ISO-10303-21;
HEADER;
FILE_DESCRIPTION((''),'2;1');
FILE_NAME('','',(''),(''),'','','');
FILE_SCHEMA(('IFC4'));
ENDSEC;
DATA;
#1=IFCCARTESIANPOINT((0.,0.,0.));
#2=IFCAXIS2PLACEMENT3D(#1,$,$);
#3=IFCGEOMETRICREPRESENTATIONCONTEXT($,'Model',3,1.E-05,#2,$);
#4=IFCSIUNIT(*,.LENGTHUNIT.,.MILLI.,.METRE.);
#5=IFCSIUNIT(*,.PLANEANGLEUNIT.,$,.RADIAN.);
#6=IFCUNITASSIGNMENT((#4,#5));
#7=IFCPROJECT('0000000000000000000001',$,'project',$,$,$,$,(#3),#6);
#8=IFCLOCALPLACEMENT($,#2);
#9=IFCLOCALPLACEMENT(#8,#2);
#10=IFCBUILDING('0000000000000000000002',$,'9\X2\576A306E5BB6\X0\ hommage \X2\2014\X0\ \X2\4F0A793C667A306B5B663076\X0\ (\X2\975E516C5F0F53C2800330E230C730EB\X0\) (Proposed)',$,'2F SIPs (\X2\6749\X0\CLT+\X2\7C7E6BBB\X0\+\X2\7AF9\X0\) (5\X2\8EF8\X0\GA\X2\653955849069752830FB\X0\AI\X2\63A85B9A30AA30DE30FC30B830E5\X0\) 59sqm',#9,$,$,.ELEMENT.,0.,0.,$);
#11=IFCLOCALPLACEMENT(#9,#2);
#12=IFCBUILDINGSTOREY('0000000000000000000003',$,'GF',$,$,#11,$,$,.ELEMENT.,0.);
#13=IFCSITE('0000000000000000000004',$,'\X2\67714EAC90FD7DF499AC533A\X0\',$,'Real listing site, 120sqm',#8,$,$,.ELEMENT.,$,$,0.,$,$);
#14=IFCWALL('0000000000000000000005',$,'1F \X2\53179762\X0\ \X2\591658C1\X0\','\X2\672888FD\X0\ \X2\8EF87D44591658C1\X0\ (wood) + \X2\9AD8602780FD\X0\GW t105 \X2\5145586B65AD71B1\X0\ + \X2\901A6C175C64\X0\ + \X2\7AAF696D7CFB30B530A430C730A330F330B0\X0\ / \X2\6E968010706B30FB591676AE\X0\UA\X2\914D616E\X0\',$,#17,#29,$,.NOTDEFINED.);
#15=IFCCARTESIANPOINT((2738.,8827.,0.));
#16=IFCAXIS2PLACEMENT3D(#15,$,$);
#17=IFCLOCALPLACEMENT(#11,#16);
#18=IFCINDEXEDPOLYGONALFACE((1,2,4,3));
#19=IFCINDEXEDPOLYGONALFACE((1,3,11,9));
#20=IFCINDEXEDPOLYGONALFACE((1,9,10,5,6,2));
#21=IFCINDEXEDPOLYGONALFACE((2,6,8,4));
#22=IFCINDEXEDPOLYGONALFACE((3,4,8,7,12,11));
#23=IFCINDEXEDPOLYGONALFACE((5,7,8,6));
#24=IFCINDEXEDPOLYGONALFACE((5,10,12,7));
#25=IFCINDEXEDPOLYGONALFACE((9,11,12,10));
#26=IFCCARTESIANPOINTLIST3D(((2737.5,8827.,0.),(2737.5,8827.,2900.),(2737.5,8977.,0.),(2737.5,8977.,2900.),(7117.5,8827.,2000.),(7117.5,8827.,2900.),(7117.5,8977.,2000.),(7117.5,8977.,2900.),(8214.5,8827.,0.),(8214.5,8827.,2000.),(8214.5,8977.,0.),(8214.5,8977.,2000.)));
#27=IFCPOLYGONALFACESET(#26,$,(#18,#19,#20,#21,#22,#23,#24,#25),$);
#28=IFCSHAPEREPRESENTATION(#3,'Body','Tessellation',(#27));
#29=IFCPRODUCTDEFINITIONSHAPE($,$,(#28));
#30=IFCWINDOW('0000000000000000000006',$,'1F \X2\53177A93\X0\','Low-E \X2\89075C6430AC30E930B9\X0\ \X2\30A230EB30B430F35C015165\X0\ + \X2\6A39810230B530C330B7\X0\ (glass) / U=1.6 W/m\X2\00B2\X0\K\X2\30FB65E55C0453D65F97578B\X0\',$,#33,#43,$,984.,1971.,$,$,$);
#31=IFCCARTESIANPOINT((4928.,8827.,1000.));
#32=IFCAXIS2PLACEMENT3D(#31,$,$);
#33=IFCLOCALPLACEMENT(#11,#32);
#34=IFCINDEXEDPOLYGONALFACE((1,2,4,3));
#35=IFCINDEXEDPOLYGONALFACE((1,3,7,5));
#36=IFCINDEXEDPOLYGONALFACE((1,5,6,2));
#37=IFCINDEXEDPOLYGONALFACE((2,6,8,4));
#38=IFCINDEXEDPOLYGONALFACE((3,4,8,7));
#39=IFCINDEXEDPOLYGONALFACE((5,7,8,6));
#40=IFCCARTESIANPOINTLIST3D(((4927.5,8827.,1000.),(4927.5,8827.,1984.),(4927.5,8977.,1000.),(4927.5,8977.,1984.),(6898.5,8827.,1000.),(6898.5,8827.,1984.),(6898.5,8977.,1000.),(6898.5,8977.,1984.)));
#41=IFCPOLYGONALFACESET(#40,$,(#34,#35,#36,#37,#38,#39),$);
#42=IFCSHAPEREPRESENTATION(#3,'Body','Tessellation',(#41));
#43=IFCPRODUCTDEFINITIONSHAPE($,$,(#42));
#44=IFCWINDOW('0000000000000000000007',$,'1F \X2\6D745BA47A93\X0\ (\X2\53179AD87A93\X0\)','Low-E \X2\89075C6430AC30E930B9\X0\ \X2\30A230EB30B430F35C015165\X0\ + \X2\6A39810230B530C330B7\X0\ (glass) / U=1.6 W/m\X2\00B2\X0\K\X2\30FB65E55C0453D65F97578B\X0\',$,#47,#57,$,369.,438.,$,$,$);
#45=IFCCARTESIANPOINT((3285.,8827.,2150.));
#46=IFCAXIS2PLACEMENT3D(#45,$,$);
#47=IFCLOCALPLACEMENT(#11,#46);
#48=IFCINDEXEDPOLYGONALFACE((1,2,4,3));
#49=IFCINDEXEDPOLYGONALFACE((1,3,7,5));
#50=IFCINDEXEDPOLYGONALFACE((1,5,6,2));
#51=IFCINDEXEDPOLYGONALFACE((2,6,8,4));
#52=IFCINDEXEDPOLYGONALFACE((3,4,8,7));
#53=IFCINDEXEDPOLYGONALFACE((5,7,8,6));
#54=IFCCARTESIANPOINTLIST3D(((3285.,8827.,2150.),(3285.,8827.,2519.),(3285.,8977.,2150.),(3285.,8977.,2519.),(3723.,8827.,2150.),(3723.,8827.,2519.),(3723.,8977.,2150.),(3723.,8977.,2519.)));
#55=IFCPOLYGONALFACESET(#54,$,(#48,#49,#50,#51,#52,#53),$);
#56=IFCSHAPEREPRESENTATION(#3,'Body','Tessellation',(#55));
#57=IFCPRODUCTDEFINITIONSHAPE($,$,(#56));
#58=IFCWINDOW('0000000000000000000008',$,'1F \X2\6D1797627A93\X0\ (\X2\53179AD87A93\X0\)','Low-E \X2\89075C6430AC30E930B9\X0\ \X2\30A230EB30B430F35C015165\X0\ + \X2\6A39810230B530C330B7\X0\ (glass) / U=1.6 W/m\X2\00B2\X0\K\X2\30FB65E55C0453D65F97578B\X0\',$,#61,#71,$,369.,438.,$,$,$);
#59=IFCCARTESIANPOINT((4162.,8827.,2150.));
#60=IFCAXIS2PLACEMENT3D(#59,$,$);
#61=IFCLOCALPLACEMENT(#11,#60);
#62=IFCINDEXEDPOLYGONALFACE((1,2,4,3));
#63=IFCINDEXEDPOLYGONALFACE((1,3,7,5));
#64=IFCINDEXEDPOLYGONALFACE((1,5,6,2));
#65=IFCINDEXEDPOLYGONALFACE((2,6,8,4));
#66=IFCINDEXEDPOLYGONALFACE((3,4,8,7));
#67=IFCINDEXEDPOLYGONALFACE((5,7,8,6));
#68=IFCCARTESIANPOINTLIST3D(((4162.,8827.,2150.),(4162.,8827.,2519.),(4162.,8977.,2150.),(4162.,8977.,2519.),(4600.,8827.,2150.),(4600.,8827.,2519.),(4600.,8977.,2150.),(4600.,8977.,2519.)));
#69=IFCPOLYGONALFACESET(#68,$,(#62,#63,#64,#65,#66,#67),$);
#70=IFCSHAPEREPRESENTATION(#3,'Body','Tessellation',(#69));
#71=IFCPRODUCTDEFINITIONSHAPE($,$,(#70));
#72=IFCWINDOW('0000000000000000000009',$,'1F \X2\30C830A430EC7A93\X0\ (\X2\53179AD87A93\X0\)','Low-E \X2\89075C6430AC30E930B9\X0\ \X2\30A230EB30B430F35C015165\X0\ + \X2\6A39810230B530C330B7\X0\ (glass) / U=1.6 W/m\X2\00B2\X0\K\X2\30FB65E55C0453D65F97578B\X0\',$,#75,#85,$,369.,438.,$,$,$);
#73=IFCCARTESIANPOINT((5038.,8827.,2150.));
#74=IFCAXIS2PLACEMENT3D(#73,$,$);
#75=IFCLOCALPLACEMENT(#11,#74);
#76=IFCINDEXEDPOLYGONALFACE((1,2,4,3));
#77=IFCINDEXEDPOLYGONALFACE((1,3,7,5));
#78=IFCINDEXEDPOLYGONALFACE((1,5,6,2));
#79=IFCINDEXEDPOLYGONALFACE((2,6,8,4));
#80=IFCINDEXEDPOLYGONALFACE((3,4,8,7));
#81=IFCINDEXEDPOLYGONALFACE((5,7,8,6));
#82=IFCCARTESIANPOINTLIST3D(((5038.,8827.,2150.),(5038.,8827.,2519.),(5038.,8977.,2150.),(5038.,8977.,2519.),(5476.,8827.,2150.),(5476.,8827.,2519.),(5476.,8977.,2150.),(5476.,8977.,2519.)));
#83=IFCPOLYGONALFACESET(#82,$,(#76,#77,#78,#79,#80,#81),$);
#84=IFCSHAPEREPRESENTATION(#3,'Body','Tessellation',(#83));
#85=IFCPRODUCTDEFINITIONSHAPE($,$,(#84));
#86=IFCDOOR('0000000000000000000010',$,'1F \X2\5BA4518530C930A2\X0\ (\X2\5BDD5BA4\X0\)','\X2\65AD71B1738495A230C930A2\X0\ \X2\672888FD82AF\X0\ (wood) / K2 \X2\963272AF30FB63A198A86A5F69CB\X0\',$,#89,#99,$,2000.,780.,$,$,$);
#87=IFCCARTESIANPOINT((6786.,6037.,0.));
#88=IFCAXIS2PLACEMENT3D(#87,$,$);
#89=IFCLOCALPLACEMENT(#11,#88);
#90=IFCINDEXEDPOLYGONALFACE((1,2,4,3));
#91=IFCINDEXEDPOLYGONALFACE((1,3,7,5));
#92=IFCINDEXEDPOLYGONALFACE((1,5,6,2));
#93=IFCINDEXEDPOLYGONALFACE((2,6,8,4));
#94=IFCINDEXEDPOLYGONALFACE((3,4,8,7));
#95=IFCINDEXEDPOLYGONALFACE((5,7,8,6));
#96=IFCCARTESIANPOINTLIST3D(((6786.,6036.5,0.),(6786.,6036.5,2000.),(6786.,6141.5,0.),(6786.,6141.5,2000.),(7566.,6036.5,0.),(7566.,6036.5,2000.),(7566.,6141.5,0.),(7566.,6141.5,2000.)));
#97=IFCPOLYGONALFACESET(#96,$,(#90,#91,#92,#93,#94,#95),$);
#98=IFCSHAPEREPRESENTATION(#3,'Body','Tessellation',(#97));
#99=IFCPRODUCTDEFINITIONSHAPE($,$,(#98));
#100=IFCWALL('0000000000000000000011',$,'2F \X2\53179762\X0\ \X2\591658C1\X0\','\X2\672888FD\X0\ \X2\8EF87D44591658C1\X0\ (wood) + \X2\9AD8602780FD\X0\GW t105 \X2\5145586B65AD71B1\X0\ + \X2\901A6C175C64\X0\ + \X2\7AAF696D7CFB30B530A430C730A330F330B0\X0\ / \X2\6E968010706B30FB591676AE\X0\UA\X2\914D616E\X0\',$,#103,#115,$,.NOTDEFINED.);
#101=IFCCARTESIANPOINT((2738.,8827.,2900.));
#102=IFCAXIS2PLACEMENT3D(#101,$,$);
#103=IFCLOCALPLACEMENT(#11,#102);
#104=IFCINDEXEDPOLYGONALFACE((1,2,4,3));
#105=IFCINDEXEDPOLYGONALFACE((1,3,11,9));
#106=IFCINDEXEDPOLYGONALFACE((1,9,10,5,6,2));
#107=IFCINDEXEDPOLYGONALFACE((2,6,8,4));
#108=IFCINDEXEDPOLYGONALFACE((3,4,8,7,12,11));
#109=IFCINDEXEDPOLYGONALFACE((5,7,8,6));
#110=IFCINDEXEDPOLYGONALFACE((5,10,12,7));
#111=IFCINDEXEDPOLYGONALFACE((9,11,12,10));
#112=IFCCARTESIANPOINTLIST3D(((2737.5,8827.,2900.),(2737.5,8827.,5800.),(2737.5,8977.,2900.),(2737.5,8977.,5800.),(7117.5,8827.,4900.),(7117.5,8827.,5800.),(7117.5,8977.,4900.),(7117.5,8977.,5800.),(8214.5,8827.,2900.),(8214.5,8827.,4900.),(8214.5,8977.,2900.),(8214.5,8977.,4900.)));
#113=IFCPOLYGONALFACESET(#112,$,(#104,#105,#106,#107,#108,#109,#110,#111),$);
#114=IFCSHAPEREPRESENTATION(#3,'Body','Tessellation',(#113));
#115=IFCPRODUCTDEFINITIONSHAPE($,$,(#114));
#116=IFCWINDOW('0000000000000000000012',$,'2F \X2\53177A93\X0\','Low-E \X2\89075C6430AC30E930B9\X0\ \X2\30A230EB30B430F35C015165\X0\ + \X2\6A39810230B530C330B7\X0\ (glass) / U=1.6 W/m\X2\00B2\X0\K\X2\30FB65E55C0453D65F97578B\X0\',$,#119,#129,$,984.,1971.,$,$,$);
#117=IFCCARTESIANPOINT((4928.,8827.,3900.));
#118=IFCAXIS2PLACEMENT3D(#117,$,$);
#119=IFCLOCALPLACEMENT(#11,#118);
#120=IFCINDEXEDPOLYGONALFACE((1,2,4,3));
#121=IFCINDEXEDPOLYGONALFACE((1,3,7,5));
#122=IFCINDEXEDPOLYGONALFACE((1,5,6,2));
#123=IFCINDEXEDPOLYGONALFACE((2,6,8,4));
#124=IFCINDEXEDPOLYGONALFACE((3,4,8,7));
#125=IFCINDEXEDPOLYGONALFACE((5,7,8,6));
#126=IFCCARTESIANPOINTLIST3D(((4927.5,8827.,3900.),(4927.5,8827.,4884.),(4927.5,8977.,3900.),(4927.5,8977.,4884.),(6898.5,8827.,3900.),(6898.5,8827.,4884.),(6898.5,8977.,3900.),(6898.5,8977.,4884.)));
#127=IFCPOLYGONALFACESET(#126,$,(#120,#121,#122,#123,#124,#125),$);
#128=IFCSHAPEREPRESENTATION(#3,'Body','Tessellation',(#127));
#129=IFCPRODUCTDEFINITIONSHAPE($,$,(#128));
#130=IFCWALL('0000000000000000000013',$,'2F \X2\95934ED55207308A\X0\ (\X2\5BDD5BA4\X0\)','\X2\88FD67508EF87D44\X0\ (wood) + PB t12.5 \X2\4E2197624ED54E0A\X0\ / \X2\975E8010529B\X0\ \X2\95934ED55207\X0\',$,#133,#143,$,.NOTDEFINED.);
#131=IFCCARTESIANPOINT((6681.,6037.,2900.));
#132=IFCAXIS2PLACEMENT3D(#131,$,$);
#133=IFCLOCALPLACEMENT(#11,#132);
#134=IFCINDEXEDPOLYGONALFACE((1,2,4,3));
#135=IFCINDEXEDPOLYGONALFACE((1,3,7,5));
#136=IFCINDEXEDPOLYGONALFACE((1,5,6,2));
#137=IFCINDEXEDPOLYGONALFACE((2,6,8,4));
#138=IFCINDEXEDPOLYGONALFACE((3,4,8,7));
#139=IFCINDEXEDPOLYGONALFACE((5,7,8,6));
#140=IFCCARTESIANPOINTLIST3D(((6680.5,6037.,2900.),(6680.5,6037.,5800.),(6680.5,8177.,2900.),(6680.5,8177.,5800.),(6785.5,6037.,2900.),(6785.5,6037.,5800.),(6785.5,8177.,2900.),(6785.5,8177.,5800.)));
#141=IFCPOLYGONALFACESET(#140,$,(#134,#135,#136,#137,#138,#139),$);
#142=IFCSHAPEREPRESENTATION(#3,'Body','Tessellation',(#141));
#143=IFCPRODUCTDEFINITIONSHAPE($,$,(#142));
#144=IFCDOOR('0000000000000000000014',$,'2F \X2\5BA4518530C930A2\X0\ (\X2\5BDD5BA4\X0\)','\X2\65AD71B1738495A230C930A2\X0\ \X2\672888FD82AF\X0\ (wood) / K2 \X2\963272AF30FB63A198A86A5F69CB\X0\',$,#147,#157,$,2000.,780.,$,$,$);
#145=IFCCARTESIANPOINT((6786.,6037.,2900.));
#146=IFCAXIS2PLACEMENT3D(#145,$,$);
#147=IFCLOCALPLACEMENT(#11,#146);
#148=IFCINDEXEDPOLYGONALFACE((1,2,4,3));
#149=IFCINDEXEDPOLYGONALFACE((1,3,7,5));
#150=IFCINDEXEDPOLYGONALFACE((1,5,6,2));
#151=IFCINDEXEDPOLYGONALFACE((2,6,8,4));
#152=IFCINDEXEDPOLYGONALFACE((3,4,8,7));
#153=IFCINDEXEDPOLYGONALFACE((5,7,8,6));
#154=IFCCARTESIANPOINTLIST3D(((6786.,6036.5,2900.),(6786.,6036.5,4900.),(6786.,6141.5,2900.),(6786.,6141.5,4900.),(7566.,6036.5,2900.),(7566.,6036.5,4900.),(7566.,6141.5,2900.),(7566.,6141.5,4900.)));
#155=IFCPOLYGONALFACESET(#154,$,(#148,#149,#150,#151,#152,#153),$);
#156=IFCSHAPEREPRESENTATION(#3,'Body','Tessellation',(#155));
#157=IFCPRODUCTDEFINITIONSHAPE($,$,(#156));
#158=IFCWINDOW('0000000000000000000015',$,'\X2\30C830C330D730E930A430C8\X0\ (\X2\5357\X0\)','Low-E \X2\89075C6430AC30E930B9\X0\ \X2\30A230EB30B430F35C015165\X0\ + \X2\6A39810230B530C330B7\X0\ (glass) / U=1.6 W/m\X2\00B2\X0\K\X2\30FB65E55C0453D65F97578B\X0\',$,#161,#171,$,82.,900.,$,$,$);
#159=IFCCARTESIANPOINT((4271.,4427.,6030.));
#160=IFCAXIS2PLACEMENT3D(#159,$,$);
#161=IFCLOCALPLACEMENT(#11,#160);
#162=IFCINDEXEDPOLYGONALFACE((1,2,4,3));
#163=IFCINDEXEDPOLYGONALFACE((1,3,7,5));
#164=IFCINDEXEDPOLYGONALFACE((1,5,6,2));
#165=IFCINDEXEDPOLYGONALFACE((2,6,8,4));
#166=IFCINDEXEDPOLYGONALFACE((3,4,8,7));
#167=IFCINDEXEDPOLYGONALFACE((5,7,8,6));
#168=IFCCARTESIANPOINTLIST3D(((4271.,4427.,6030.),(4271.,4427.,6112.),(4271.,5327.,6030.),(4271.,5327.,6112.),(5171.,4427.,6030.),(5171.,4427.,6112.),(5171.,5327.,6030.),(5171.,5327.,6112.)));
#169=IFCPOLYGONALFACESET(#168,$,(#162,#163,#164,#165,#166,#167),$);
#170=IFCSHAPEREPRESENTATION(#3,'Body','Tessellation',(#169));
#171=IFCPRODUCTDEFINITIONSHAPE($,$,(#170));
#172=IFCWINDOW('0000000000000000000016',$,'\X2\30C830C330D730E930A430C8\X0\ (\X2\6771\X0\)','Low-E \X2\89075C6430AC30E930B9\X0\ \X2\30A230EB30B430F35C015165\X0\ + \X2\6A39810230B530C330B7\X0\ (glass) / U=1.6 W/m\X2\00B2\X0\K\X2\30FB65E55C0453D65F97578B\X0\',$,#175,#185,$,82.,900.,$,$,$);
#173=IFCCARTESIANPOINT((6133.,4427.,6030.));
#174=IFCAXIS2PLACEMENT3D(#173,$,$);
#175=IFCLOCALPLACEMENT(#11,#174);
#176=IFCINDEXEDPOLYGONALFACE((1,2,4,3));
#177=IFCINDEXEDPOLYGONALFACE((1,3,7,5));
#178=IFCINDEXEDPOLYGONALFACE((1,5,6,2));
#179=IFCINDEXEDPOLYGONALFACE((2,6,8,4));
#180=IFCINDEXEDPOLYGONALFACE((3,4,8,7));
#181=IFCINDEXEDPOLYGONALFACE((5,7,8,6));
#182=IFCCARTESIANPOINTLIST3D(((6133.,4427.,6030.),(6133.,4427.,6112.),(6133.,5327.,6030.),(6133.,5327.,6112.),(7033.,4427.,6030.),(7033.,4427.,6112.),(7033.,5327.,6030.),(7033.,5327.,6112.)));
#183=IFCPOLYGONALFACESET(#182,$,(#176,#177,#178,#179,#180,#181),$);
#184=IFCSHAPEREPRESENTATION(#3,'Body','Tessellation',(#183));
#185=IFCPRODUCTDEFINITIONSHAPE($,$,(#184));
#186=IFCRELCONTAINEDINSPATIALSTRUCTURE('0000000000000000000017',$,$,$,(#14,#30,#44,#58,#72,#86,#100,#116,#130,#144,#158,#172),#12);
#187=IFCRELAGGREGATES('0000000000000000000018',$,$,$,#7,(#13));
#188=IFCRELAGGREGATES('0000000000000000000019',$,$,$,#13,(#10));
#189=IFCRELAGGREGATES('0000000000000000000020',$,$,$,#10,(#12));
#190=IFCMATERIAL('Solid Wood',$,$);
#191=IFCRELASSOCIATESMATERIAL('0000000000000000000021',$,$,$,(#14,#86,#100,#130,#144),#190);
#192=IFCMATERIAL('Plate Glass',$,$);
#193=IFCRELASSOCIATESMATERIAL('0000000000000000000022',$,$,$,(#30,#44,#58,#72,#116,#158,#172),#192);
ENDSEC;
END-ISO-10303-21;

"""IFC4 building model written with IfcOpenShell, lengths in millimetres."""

from ifc_helpers import new_model, si_unit, frame, frame_2d, origin, place, context, project, spatial, rectangle, extrude, material, element, fill, save


model = new_model("IFC4")

# Units and contexts
model_context = context("Model", 3, precision=1e-05, world=origin())
ifc_project = project(units=[si_unit("LENGTHUNIT", "METRE", prefix="MILLI"), si_unit("PLANEANGLEUNIT", "RADIAN")], contexts=[model_context])

# Site, building, storey
site_placement = place(None, origin())
site = spatial("IfcSite", under=ifc_project, at=site_placement, Name="東京都練馬区", ObjectType="Real listing site, 120sqm", CompositionType="ELEMENT", RefElevation=0.0)
building_placement = place(site_placement, origin())
building = spatial("IfcBuilding", under=site, at=building_placement, Name="9坪の家 hommage — 伊礼智に学ぶ (非公式参考モデル) (Proposed)", ObjectType="2F SIPs (杉CLT+籾殻+竹) (5軸GA改善適用・AI推定オマージュ) 59sqm", CompositionType="ELEMENT", ElevationOfRefHeight=0.0, ElevationOfTerrain=0.0)
storey_placement = place(building_placement, origin())
storey = spatial("IfcBuildingStorey", under=building, at=storey_placement, Name="GF", CompositionType="ELEMENT", Elevation=0.0)

# Wall, openings, windows
ifc_material_1 = material(Name="Solid Wood")
wall_1_placement = place(storey_placement, frame((2738.0, 8827.0, 0.0)))
wall_1 = element("IfcWall", 1, at=wall_1_placement, inside=storey, material=ifc_material_1, Name="1F 北面 外壁", Description="木製 軸組外壁 (wood) + 高性能GW t105 充填断熱 + 通気層 + 窯業系サイディング / 準耐火・外皮UA配慮", PredefinedType="NOTDEFINED", context=model_context, shape_type="SweptSolid", body=[
    extrude(rectangle(XDim=5477.0, YDim=150.0, at=frame_2d((2738.0, 75.0))), frame((2738.0, 8827.0, 0.0)), (0.0, 0.0, 1.0), 2900.0),
])
opening_1_placement = place(storey_placement, frame((4928.0, 8827.0, 1000.0)))
opening_1 = element("IfcOpeningElement", 2, at=opening_1_placement, cuts=wall_1, PredefinedType="NOTDEFINED", context=model_context, shape_type="SweptSolid", body=[
    extrude(rectangle(XDim=1971.0, YDim=150.0, at=frame_2d((985.0, 75.0))), frame((4928.0, 8827.0, 1000.0)), (0.0, 0.0, 1.0), 984.0),
])
opening_2_placement = place(storey_placement, frame((3285.0, 8827.0, 2150.0)))
opening_2 = element("IfcOpeningElement", 3, at=opening_2_placement, cuts=wall_1, PredefinedType="NOTDEFINED", context=model_context, shape_type="SweptSolid", body=[
    extrude(rectangle(XDim=438.0, YDim=150.0, at=frame_2d((219.0, 75.0))), frame((3285.0, 8827.0, 2150.0)), (0.0, 0.0, 1.0), 369.0),
])
opening_3_placement = place(storey_placement, frame((4162.0, 8827.0, 2150.0)))
opening_3 = element("IfcOpeningElement", 4, at=opening_3_placement, cuts=wall_1, PredefinedType="NOTDEFINED", context=model_context, shape_type="SweptSolid", body=[
    extrude(rectangle(XDim=438.0, YDim=150.0, at=frame_2d((219.0, 75.0))), frame((4162.0, 8827.0, 2150.0)), (0.0, 0.0, 1.0), 369.0),
])
opening_4_placement = place(storey_placement, frame((5038.0, 8827.0, 2150.0)))
opening_4 = element("IfcOpeningElement", 5, at=opening_4_placement, cuts=wall_1, PredefinedType="NOTDEFINED", context=model_context, shape_type="SweptSolid", body=[
    extrude(rectangle(XDim=438.0, YDim=150.0, at=frame_2d((219.0, 75.0))), frame((5038.0, 8827.0, 2150.0)), (0.0, 0.0, 1.0), 369.0),
])
ifc_material_2 = material(Name="Plate Glass")
window_1_placement = place(storey_placement, frame((4928.0, 8827.0, 1000.0)))
window_1 = element("IfcWindow", 6, at=window_1_placement, inside=storey, material=ifc_material_2, Name="1F 北窓", Description="Low-E 複層ガラス アルゴン封入 + 樹脂サッシ (glass) / U=1.6 W/m²K・日射取得型", OverallHeight=984.0, OverallWidth=1971.0, context=model_context, shape_type="SweptSolid", body=[
    extrude(rectangle(XDim=1971.0, YDim=150.0, at=frame_2d((985.0, 75.0))), frame((4928.0, 8827.0, 1000.0)), (0.0, 0.0, 1.0), 984.0),
])
fill(opening_1, window_1)
window_2_placement = place(storey_placement, frame((3285.0, 8827.0, 2150.0)))
window_2 = element("IfcWindow", 7, at=window_2_placement, inside=storey, material=ifc_material_2, Name="1F 浴室窓 (北高窓)", Description="Low-E 複層ガラス アルゴン封入 + 樹脂サッシ (glass) / U=1.6 W/m²K・日射取得型", OverallHeight=369.0, OverallWidth=438.0, context=model_context, shape_type="SweptSolid", body=[
    extrude(rectangle(XDim=438.0, YDim=150.0, at=frame_2d((219.0, 75.0))), frame((3285.0, 8827.0, 2150.0)), (0.0, 0.0, 1.0), 369.0),
])
fill(opening_2, window_2)
window_3_placement = place(storey_placement, frame((4162.0, 8827.0, 2150.0)))
window_3 = element("IfcWindow", 8, at=window_3_placement, inside=storey, material=ifc_material_2, Name="1F 洗面窓 (北高窓)", Description="Low-E 複層ガラス アルゴン封入 + 樹脂サッシ (glass) / U=1.6 W/m²K・日射取得型", OverallHeight=369.0, OverallWidth=438.0, context=model_context, shape_type="SweptSolid", body=[
    extrude(rectangle(XDim=438.0, YDim=150.0, at=frame_2d((219.0, 75.0))), frame((4162.0, 8827.0, 2150.0)), (0.0, 0.0, 1.0), 369.0),
])
fill(opening_3, window_3)
window_4_placement = place(storey_placement, frame((5038.0, 8827.0, 2150.0)))
window_4 = element("IfcWindow", 9, at=window_4_placement, inside=storey, material=ifc_material_2, Name="1F トイレ窓 (北高窓)", Description="Low-E 複層ガラス アルゴン封入 + 樹脂サッシ (glass) / U=1.6 W/m²K・日射取得型", OverallHeight=369.0, OverallWidth=438.0, context=model_context, shape_type="SweptSolid", body=[
    extrude(rectangle(XDim=438.0, YDim=150.0, at=frame_2d((219.0, 75.0))), frame((5038.0, 8827.0, 2150.0)), (0.0, 0.0, 1.0), 369.0),
])
fill(opening_4, window_4)

# Door
door_1_placement = place(storey_placement, frame((6786.0, 6037.0, 0.0)))
element("IfcDoor", 10, at=door_1_placement, inside=storey, material=ifc_material_1, Name="1F 室内ドア (寝室)", Description="断熱玄関ドア 木製芯 (wood) / K2 防犯・採風機構", OverallHeight=2000.0, OverallWidth=780.0, context=model_context, shape_type="SweptSolid", body=[
    extrude(rectangle(XDim=780.0, YDim=105.0, at=frame_2d((390.0, 52.0))), frame((6786.0, 6037.0, 0.0)), (0.0, 0.0, 1.0), 2000.0),
])

# Wall, opening, window
wall_2_placement = place(storey_placement, frame((2738.0, 8827.0, 2900.0)))
wall_2 = element("IfcWall", 11, at=wall_2_placement, inside=storey, material=ifc_material_1, Name="2F 北面 外壁", Description="木製 軸組外壁 (wood) + 高性能GW t105 充填断熱 + 通気層 + 窯業系サイディング / 準耐火・外皮UA配慮", PredefinedType="NOTDEFINED", context=model_context, shape_type="SweptSolid", body=[
    extrude(rectangle(XDim=5477.0, YDim=150.0, at=frame_2d((2738.0, 75.0))), frame((2738.0, 8827.0, 2900.0)), (0.0, 0.0, 1.0), 2900.0),
])
opening_5_placement = place(storey_placement, frame((4928.0, 8827.0, 3900.0)))
opening_5 = element("IfcOpeningElement", 12, at=opening_5_placement, cuts=wall_2, PredefinedType="NOTDEFINED", context=model_context, shape_type="SweptSolid", body=[
    extrude(rectangle(XDim=1971.0, YDim=150.0, at=frame_2d((985.0, 75.0))), frame((4928.0, 8827.0, 3900.0)), (0.0, 0.0, 1.0), 984.0),
])
window_5_placement = place(storey_placement, frame((4928.0, 8827.0, 3900.0)))
window_5 = element("IfcWindow", 13, at=window_5_placement, inside=storey, material=ifc_material_2, Name="2F 北窓", Description="Low-E 複層ガラス アルゴン封入 + 樹脂サッシ (glass) / U=1.6 W/m²K・日射取得型", OverallHeight=984.0, OverallWidth=1971.0, context=model_context, shape_type="SweptSolid", body=[
    extrude(rectangle(XDim=1971.0, YDim=150.0, at=frame_2d((985.0, 75.0))), frame((4928.0, 8827.0, 3900.0)), (0.0, 0.0, 1.0), 984.0),
])
fill(opening_5, window_5)

# Wall
wall_3_placement = place(storey_placement, frame((6681.0, 6037.0, 2900.0)))
element("IfcWall", 14, at=wall_3_placement, inside=storey, material=ifc_material_1, Name="2F 間仕切り (寝室)", Description="製材軸組 (wood) + PB t12.5 両面仕上 / 非耐力 間仕切", PredefinedType="NOTDEFINED", context=model_context, shape_type="SweptSolid", body=[
    extrude(rectangle(XDim=105.0, YDim=2140.0, at=frame_2d((52.0, 1070.0))), frame((6681.0, 6037.0, 2900.0)), (0.0, 0.0, 1.0), 2900.0),
])

# Door
door_2_placement = place(storey_placement, frame((6786.0, 6037.0, 2900.0)))
element("IfcDoor", 15, at=door_2_placement, inside=storey, material=ifc_material_1, Name="2F 室内ドア (寝室)", Description="断熱玄関ドア 木製芯 (wood) / K2 防犯・採風機構", OverallHeight=2000.0, OverallWidth=780.0, context=model_context, shape_type="SweptSolid", body=[
    extrude(rectangle(XDim=780.0, YDim=105.0, at=frame_2d((390.0, 52.0))), frame((6786.0, 6037.0, 2900.0)), (0.0, 0.0, 1.0), 2000.0),
])

# Windows
window_6_placement = place(storey_placement, frame((4271.0, 4427.0, 6030.0)))
element("IfcWindow", 16, at=window_6_placement, inside=storey, material=ifc_material_2, Name="トップライト (南)", Description="Low-E 複層ガラス アルゴン封入 + 樹脂サッシ (glass) / U=1.6 W/m²K・日射取得型", OverallHeight=82.0, OverallWidth=900.0, context=model_context, shape_type="SweptSolid", body=[
    extrude(rectangle(XDim=900.0, YDim=900.0, at=frame_2d((450.0, 450.0))), frame((4271.0, 4427.0, 6030.0)), (0.0, 0.0, 1.0), 82.0),
])
window_7_placement = place(storey_placement, frame((6133.0, 4427.0, 6030.0)))
element("IfcWindow", 17, at=window_7_placement, inside=storey, material=ifc_material_2, Name="トップライト (東)", Description="Low-E 複層ガラス アルゴン封入 + 樹脂サッシ (glass) / U=1.6 W/m²K・日射取得型", OverallHeight=82.0, OverallWidth=900.0, context=model_context, shape_type="SweptSolid", body=[
    extrude(rectangle(XDim=900.0, YDim=900.0, at=frame_2d((450.0, 450.0))), frame((6133.0, 4427.0, 6030.0)), (0.0, 0.0, 1.0), 82.0),
])

save(model, "model.ifc")
